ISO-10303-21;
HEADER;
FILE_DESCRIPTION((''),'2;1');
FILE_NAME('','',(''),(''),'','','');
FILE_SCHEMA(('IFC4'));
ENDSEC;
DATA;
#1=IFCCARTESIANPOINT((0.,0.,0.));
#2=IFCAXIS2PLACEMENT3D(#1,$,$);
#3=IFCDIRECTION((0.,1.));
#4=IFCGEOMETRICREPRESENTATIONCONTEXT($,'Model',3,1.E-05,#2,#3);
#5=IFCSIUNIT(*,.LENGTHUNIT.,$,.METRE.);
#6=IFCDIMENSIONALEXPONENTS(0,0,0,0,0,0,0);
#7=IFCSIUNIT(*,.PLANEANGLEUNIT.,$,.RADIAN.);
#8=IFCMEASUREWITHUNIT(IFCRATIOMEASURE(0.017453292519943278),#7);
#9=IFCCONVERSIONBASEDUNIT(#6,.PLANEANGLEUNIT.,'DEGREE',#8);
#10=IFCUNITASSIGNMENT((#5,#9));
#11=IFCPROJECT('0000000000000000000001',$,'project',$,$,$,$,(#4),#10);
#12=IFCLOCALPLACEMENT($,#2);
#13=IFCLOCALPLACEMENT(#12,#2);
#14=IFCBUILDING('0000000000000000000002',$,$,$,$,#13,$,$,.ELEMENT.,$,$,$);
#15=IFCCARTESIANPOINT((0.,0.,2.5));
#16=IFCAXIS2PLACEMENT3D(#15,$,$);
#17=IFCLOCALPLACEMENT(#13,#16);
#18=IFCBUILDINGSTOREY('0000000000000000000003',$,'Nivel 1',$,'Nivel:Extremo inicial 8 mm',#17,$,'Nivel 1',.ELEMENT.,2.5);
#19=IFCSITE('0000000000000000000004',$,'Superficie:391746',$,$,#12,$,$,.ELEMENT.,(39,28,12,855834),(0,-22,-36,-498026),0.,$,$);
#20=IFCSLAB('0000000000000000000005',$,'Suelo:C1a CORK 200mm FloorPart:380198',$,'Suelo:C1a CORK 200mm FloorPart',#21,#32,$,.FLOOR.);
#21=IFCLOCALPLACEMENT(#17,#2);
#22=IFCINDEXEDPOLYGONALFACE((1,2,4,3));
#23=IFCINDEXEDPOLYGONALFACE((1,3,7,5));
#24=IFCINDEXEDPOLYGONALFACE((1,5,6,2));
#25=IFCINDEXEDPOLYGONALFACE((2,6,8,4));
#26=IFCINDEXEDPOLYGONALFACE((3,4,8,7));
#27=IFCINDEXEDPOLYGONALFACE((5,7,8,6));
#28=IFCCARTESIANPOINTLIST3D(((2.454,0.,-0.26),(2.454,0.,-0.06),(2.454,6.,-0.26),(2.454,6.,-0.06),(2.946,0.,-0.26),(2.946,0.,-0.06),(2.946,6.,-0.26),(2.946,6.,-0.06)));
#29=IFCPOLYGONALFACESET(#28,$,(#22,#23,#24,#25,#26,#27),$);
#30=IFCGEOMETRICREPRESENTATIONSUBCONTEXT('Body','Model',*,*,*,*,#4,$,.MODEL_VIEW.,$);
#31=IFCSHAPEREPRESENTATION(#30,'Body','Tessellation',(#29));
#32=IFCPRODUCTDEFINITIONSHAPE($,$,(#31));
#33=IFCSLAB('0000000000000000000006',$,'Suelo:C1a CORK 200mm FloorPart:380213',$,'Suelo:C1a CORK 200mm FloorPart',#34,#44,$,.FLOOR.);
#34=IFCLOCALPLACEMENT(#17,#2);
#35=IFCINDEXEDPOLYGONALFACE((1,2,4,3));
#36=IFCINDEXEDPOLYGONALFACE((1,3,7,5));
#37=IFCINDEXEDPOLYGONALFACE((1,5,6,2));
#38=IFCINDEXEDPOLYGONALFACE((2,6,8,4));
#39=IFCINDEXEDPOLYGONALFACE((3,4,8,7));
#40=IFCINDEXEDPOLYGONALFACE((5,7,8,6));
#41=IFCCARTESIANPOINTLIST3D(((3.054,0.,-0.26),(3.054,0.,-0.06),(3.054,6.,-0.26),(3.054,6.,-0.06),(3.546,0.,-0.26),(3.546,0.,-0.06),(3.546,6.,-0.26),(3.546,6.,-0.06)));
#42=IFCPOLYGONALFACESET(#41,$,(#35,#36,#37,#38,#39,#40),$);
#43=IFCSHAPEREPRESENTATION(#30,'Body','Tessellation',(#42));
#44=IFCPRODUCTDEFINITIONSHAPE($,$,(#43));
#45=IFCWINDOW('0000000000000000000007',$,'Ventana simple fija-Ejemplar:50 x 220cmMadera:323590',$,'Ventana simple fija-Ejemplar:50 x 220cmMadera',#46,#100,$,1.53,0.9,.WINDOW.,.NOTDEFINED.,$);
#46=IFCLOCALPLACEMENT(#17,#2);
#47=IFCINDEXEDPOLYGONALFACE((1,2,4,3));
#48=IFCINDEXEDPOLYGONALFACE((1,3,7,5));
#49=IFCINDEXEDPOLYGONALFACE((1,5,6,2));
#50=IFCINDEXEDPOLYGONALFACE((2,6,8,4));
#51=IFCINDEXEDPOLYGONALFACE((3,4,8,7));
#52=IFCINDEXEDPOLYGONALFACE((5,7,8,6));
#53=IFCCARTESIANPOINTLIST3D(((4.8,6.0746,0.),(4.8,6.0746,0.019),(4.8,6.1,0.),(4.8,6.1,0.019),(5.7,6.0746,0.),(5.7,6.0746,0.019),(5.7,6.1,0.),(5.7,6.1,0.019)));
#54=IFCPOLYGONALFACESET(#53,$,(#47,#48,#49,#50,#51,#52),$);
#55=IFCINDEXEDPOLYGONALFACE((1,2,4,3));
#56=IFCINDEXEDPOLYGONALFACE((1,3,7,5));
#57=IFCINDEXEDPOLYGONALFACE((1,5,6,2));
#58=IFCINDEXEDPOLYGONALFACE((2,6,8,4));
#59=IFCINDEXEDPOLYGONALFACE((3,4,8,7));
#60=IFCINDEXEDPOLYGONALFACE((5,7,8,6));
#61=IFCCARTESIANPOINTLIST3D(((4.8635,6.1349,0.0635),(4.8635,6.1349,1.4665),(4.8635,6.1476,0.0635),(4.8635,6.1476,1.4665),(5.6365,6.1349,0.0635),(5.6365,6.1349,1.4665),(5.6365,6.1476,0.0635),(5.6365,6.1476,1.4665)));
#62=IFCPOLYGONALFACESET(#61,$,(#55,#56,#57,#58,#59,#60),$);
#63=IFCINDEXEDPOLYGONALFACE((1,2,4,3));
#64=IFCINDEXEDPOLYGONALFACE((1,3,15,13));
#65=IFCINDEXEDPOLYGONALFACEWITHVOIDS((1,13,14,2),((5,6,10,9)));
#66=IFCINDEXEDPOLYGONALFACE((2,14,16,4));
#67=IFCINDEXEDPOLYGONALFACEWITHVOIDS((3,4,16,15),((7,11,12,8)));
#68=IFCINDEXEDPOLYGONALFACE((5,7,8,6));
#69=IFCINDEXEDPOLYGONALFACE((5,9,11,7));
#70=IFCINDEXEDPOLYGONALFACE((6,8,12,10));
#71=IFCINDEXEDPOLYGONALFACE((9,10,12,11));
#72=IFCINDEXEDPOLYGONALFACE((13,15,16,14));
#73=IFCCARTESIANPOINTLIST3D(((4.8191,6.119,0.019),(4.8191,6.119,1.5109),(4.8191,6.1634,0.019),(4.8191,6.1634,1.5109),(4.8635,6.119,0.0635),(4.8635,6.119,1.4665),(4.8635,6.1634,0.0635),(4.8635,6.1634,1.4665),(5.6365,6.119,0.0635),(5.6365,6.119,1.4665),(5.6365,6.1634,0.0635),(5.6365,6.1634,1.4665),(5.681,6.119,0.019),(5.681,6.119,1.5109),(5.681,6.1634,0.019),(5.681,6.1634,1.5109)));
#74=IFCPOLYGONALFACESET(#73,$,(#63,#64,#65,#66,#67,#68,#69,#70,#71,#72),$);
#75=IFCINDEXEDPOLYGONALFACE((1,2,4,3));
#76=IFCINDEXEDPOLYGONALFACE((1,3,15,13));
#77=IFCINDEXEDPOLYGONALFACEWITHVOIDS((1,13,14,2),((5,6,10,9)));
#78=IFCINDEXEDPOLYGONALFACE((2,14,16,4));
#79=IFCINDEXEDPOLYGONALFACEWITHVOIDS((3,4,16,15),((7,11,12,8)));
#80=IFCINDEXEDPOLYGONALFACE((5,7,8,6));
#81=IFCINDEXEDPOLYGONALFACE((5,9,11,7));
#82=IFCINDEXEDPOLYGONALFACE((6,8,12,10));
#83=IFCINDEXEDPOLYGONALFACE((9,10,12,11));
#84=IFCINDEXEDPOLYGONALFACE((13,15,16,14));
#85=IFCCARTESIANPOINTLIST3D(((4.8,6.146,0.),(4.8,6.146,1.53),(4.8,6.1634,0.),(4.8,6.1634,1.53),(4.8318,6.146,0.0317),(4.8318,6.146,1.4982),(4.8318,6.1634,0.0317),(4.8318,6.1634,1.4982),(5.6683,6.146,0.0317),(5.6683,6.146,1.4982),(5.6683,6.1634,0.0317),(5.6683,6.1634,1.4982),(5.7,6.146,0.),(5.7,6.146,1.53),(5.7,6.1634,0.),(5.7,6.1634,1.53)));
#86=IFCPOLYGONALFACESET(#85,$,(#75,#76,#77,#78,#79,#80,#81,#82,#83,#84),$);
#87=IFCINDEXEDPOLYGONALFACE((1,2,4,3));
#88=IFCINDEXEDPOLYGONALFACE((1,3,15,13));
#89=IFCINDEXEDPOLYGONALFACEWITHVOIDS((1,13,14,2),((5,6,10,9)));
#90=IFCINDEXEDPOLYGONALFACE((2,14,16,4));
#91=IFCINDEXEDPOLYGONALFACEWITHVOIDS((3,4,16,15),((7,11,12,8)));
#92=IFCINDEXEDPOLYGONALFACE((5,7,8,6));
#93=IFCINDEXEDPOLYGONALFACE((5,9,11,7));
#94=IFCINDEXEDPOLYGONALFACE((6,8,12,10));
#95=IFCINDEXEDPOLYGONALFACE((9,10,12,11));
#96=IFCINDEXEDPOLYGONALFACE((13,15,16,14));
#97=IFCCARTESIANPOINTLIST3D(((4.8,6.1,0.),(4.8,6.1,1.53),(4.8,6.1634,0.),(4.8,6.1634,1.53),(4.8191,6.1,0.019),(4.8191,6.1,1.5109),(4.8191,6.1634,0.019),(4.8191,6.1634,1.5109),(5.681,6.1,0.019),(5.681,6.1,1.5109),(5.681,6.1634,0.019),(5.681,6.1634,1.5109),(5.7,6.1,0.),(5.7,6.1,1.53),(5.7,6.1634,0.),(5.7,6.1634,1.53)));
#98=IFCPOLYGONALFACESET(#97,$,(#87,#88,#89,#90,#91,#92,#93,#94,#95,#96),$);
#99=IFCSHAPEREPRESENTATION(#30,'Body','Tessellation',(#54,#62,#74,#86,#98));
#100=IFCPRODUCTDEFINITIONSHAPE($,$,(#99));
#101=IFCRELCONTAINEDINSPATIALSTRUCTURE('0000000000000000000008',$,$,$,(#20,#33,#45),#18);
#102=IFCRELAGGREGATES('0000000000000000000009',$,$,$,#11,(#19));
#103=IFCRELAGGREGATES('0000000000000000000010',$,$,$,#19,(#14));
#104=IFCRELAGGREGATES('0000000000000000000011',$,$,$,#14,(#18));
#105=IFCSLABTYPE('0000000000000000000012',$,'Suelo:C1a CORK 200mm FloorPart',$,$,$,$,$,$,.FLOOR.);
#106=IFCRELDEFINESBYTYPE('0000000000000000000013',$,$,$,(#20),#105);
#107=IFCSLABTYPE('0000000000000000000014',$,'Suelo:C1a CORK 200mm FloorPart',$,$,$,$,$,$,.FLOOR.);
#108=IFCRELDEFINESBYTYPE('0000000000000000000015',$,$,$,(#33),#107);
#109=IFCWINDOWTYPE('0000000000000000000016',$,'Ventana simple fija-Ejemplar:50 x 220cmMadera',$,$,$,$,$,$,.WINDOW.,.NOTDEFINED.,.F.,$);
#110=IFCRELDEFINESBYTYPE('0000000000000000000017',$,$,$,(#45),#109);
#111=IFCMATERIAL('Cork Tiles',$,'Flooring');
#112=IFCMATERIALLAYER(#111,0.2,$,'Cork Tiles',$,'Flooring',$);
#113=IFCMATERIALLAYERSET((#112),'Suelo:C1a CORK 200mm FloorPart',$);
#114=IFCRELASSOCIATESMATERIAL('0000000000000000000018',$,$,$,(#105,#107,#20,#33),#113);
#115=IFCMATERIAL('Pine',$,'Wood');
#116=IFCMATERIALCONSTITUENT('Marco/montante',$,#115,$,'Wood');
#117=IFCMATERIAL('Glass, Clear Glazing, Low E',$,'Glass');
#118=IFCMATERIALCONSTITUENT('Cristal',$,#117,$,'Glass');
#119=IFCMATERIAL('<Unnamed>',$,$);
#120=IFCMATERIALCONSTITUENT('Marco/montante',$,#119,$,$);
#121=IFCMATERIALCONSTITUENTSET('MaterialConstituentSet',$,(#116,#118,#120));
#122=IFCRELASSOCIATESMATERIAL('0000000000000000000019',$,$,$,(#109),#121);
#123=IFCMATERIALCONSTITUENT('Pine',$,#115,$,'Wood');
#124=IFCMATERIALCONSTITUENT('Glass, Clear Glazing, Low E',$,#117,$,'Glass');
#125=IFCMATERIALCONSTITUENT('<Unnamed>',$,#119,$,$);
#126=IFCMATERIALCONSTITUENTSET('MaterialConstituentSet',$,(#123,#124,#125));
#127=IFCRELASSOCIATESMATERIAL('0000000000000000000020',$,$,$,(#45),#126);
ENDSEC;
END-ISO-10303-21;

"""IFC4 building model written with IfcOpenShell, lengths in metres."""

from ifc_helpers import new_model, entity, si_unit, converted_unit, direction, frame, frame_2d, origin, origin_2d_with_axis, place, context, subcontext, project, spatial, polyline, rectangle, outline, extrude, source, transform, mapped, material, layer, layer_set, layer_usage, constituent, constituent_set, type_object, type_shapes, element, save


model = new_model("IFC4")

# Units and contexts
model_context = context("Model", 3, precision=1e-05, world=origin(), true_north=direction((0.0, 1.0)))
body_context = subcontext(model_context, "Body", "Model", "MODEL_VIEW")
ifc_project = project(units=[si_unit("LENGTHUNIT", "METRE"), converted_unit("PLANEANGLEUNIT", "DEGREE", entity("IfcRatioMeasure", 0.017453292519943278), si_unit("PLANEANGLEUNIT", "RADIAN"), dimensions=[0, 0, 0, 0, 0, 0, 0])], contexts=[model_context])

# Site, building, storey
site_placement = place(None, origin())
site = spatial("IfcSite", under=ifc_project, at=site_placement, Name="Superficie:391746", CompositionType="ELEMENT", RefLatitude=(39, 28, 12, 855834), RefLongitude=(0, -22, -36, -498026), RefElevation=0.0)
building_placement = place(site_placement, origin())
building = spatial("IfcBuilding", under=site, at=building_placement, CompositionType="ELEMENT")
storey_placement = place(building_placement, frame((0.0, 0.0, 2.5)))
storey = spatial("IfcBuildingStorey", under=building, at=storey_placement, Name="Nivel 1", ObjectType="Nivel:Extremo inicial 8 mm", LongName="Nivel 1", CompositionType="ELEMENT", Elevation=2.5)

# Slabs
ifc_material_1 = material(Name="Cork Tiles", Category="Flooring")
ifc_layer_1 = layer(ifc_material_1, 0.2, Name="Cork Tiles", Category="Flooring")
ifc_layer_set_1 = layer_set([ifc_layer_1], Name="Suelo:C1a CORK 200mm FloorPart")
ifc_layer_usage_1 = layer_usage(ifc_layer_set_1, "AXIS3", "POSITIVE", 0.0)
slab_type_1 = type_object("IfcSlabType", Name="Suelo:C1a CORK 200mm FloorPart", PredefinedType="FLOOR", material=ifc_layer_set_1)
slab_1_placement = place(storey_placement, origin())
element("IfcSlab", 1, at=slab_1_placement, inside=storey, type_object=slab_type_1, material=ifc_layer_usage_1, Name="Suelo:C1a CORK 200mm FloorPart:380198", ObjectType="Suelo:C1a CORK 200mm FloorPart", PredefinedType="FLOOR", context=body_context, shape_type="SweptSolid", body=[
    extrude(rectangle(XDim=6.0, YDim=0.492, at=frame_2d((0.0, 0.0), x_axis=(1.0, 0.0))), frame((2.7, 3.0, -0.06), z_axis=(0.0, 0.0, -1.0), x_axis=(0.0, 1.0, 0.0)), (0.0, 0.0, 1.0), 0.2),
])
ifc_layer_usage_2 = layer_usage(ifc_layer_set_1, "AXIS3", "POSITIVE", 0.0)
slab_type_2 = type_object("IfcSlabType", Name="Suelo:C1a CORK 200mm FloorPart", PredefinedType="FLOOR", material=ifc_layer_set_1)
slab_2_placement = place(storey_placement, origin())
element("IfcSlab", 2, at=slab_2_placement, inside=storey, type_object=slab_type_2, material=ifc_layer_usage_2, Name="Suelo:C1a CORK 200mm FloorPart:380213", ObjectType="Suelo:C1a CORK 200mm FloorPart", PredefinedType="FLOOR", context=body_context, shape_type="SweptSolid", body=[
    extrude(rectangle(XDim=6.0, YDim=0.492, at=frame_2d((0.0, 0.0), x_axis=(1.0, 0.0))), frame((3.3, 3.0, -0.06), z_axis=(0.0, 0.0, -1.0), x_axis=(0.0, 1.0, 0.0)), (0.0, 0.0, 1.0), 0.2),
])

# Window
ifc_material_2 = material(Name="Pine", Category="Wood")
ifc_constituent_1 = constituent(ifc_material_2, Name="Pine", Category="Wood")
ifc_material_3 = material(Name="Glass, Clear Glazing, Low E", Category="Glass")
ifc_constituent_2 = constituent(ifc_material_3, Name="Glass, Clear Glazing, Low E", Category="Glass")
ifc_material_4 = material(Name="<Unnamed>")
ifc_constituent_3 = constituent(ifc_material_4, Name="<Unnamed>")
ifc_constituent_set_1 = constituent_set(constituents=[ifc_constituent_1, ifc_constituent_2, ifc_constituent_3], Name="MaterialConstituentSet")
ifc_constituent_4 = constituent(ifc_material_2, Name="Marco/montante", Category="Wood")
ifc_constituent_5 = constituent(ifc_material_3, Name="Cristal", Category="Glass")
ifc_constituent_6 = constituent(ifc_material_4, Name="Marco/montante")
ifc_constituent_set_2 = constituent_set(constituents=[ifc_constituent_4, ifc_constituent_5, ifc_constituent_6], Name="MaterialConstituentSet")
window_type = type_object("IfcWindowType", Name="Ventana simple fija-Ejemplar:50 x 220cmMadera", ParameterTakesPrecedence=False, PartitioningType="NOTDEFINED", PredefinedType="WINDOW", material=ifc_constituent_set_2)
shared_shape_1 = source(origin(), body_context, "Body", "SweptSolid", [
    extrude(rectangle(XDim=0.9, YDim=0.0254, at=origin_2d_with_axis()), frame((0.5262, 0.0587, 0.0), z_axis=(0.0, 0.0, 1.0), x_axis=(-1.0, 0.0, 0.0)), (0.0, 0.0, 1.0), 0.019),
    extrude(rectangle(XDim=0.773, YDim=0.0127, at=origin_2d_with_axis()), frame((0.5262, 0.0048, 0.0635)), (0.0, 0.0, 1.0), 1.403),
    extrude(outline(polyline([(-0.431, -0.7459), (0.431, -0.7459), (0.431, 0.7459), (-0.431, 0.7459), (-0.431, -0.7459)]), holes=[polyline([(-0.3865, -0.7015), (-0.3865, 0.7015), (0.3865, 0.7015), (0.3865, -0.7015), (-0.3865, -0.7015)])]), frame((0.5262, 0.027, 0.765), z_axis=(0.0, -1.0, 0.0), x_axis=(-1.0, 0.0, 0.0)), (0.0, 0.0, 1.0), 0.0444),
    extrude(outline(polyline([(-0.45, -0.765), (0.45, -0.765), (0.45, 0.765), (-0.45, 0.765), (-0.45, -0.765)]), holes=[polyline([(-0.4183, -0.7332), (-0.4183, 0.7332), (0.4183, 0.7332), (0.4183, -0.7332), (-0.4183, -0.7332)])]), frame((0.5262, 0.0, 0.765), z_axis=(0.0, -1.0, 0.0), x_axis=(-1.0, 0.0, 0.0)), (0.0, 0.0, 1.0), 0.0175),
    extrude(outline(polyline([(-0.765, -0.45), (0.765, -0.45), (0.765, 0.45), (-0.765, 0.45), (-0.765, -0.45)]), holes=[polyline([(-0.7459, -0.431), (-0.7459, 0.431), (0.7459, 0.431), (0.7459, -0.431), (-0.7459, -0.431)])]), frame((0.5262, 0.046, 0.765), z_axis=(0.0, -1.0, 0.0), x_axis=(0.0, 0.0, -1.0)), (0.0, 0.0, 1.0), 0.0635),
])
type_shapes(window_type, [shared_shape_1])
window_placement = place(storey_placement, frame((5.7762, 6.146, 0.0), z_axis=(0.0, 0.0, 1.0), x_axis=(-1.0, 0.0, 0.0)))
element("IfcWindow", 3, at=window_placement, inside=storey, type_object=window_type, material=ifc_constituent_set_1, Name="Ventana simple fija-Ejemplar:50 x 220cmMadera:323590", ObjectType="Ventana simple fija-Ejemplar:50 x 220cmMadera", OverallHeight=1.53, OverallWidth=0.9, PartitioningType="NOTDEFINED", PredefinedType="WINDOW", context=body_context, shape_type="MappedRepresentation", body=[
    mapped(shared_shape_1, transform((0.0, 0.0, 0.0), scale=1.0)),
])

save(model, "model.ifc")
